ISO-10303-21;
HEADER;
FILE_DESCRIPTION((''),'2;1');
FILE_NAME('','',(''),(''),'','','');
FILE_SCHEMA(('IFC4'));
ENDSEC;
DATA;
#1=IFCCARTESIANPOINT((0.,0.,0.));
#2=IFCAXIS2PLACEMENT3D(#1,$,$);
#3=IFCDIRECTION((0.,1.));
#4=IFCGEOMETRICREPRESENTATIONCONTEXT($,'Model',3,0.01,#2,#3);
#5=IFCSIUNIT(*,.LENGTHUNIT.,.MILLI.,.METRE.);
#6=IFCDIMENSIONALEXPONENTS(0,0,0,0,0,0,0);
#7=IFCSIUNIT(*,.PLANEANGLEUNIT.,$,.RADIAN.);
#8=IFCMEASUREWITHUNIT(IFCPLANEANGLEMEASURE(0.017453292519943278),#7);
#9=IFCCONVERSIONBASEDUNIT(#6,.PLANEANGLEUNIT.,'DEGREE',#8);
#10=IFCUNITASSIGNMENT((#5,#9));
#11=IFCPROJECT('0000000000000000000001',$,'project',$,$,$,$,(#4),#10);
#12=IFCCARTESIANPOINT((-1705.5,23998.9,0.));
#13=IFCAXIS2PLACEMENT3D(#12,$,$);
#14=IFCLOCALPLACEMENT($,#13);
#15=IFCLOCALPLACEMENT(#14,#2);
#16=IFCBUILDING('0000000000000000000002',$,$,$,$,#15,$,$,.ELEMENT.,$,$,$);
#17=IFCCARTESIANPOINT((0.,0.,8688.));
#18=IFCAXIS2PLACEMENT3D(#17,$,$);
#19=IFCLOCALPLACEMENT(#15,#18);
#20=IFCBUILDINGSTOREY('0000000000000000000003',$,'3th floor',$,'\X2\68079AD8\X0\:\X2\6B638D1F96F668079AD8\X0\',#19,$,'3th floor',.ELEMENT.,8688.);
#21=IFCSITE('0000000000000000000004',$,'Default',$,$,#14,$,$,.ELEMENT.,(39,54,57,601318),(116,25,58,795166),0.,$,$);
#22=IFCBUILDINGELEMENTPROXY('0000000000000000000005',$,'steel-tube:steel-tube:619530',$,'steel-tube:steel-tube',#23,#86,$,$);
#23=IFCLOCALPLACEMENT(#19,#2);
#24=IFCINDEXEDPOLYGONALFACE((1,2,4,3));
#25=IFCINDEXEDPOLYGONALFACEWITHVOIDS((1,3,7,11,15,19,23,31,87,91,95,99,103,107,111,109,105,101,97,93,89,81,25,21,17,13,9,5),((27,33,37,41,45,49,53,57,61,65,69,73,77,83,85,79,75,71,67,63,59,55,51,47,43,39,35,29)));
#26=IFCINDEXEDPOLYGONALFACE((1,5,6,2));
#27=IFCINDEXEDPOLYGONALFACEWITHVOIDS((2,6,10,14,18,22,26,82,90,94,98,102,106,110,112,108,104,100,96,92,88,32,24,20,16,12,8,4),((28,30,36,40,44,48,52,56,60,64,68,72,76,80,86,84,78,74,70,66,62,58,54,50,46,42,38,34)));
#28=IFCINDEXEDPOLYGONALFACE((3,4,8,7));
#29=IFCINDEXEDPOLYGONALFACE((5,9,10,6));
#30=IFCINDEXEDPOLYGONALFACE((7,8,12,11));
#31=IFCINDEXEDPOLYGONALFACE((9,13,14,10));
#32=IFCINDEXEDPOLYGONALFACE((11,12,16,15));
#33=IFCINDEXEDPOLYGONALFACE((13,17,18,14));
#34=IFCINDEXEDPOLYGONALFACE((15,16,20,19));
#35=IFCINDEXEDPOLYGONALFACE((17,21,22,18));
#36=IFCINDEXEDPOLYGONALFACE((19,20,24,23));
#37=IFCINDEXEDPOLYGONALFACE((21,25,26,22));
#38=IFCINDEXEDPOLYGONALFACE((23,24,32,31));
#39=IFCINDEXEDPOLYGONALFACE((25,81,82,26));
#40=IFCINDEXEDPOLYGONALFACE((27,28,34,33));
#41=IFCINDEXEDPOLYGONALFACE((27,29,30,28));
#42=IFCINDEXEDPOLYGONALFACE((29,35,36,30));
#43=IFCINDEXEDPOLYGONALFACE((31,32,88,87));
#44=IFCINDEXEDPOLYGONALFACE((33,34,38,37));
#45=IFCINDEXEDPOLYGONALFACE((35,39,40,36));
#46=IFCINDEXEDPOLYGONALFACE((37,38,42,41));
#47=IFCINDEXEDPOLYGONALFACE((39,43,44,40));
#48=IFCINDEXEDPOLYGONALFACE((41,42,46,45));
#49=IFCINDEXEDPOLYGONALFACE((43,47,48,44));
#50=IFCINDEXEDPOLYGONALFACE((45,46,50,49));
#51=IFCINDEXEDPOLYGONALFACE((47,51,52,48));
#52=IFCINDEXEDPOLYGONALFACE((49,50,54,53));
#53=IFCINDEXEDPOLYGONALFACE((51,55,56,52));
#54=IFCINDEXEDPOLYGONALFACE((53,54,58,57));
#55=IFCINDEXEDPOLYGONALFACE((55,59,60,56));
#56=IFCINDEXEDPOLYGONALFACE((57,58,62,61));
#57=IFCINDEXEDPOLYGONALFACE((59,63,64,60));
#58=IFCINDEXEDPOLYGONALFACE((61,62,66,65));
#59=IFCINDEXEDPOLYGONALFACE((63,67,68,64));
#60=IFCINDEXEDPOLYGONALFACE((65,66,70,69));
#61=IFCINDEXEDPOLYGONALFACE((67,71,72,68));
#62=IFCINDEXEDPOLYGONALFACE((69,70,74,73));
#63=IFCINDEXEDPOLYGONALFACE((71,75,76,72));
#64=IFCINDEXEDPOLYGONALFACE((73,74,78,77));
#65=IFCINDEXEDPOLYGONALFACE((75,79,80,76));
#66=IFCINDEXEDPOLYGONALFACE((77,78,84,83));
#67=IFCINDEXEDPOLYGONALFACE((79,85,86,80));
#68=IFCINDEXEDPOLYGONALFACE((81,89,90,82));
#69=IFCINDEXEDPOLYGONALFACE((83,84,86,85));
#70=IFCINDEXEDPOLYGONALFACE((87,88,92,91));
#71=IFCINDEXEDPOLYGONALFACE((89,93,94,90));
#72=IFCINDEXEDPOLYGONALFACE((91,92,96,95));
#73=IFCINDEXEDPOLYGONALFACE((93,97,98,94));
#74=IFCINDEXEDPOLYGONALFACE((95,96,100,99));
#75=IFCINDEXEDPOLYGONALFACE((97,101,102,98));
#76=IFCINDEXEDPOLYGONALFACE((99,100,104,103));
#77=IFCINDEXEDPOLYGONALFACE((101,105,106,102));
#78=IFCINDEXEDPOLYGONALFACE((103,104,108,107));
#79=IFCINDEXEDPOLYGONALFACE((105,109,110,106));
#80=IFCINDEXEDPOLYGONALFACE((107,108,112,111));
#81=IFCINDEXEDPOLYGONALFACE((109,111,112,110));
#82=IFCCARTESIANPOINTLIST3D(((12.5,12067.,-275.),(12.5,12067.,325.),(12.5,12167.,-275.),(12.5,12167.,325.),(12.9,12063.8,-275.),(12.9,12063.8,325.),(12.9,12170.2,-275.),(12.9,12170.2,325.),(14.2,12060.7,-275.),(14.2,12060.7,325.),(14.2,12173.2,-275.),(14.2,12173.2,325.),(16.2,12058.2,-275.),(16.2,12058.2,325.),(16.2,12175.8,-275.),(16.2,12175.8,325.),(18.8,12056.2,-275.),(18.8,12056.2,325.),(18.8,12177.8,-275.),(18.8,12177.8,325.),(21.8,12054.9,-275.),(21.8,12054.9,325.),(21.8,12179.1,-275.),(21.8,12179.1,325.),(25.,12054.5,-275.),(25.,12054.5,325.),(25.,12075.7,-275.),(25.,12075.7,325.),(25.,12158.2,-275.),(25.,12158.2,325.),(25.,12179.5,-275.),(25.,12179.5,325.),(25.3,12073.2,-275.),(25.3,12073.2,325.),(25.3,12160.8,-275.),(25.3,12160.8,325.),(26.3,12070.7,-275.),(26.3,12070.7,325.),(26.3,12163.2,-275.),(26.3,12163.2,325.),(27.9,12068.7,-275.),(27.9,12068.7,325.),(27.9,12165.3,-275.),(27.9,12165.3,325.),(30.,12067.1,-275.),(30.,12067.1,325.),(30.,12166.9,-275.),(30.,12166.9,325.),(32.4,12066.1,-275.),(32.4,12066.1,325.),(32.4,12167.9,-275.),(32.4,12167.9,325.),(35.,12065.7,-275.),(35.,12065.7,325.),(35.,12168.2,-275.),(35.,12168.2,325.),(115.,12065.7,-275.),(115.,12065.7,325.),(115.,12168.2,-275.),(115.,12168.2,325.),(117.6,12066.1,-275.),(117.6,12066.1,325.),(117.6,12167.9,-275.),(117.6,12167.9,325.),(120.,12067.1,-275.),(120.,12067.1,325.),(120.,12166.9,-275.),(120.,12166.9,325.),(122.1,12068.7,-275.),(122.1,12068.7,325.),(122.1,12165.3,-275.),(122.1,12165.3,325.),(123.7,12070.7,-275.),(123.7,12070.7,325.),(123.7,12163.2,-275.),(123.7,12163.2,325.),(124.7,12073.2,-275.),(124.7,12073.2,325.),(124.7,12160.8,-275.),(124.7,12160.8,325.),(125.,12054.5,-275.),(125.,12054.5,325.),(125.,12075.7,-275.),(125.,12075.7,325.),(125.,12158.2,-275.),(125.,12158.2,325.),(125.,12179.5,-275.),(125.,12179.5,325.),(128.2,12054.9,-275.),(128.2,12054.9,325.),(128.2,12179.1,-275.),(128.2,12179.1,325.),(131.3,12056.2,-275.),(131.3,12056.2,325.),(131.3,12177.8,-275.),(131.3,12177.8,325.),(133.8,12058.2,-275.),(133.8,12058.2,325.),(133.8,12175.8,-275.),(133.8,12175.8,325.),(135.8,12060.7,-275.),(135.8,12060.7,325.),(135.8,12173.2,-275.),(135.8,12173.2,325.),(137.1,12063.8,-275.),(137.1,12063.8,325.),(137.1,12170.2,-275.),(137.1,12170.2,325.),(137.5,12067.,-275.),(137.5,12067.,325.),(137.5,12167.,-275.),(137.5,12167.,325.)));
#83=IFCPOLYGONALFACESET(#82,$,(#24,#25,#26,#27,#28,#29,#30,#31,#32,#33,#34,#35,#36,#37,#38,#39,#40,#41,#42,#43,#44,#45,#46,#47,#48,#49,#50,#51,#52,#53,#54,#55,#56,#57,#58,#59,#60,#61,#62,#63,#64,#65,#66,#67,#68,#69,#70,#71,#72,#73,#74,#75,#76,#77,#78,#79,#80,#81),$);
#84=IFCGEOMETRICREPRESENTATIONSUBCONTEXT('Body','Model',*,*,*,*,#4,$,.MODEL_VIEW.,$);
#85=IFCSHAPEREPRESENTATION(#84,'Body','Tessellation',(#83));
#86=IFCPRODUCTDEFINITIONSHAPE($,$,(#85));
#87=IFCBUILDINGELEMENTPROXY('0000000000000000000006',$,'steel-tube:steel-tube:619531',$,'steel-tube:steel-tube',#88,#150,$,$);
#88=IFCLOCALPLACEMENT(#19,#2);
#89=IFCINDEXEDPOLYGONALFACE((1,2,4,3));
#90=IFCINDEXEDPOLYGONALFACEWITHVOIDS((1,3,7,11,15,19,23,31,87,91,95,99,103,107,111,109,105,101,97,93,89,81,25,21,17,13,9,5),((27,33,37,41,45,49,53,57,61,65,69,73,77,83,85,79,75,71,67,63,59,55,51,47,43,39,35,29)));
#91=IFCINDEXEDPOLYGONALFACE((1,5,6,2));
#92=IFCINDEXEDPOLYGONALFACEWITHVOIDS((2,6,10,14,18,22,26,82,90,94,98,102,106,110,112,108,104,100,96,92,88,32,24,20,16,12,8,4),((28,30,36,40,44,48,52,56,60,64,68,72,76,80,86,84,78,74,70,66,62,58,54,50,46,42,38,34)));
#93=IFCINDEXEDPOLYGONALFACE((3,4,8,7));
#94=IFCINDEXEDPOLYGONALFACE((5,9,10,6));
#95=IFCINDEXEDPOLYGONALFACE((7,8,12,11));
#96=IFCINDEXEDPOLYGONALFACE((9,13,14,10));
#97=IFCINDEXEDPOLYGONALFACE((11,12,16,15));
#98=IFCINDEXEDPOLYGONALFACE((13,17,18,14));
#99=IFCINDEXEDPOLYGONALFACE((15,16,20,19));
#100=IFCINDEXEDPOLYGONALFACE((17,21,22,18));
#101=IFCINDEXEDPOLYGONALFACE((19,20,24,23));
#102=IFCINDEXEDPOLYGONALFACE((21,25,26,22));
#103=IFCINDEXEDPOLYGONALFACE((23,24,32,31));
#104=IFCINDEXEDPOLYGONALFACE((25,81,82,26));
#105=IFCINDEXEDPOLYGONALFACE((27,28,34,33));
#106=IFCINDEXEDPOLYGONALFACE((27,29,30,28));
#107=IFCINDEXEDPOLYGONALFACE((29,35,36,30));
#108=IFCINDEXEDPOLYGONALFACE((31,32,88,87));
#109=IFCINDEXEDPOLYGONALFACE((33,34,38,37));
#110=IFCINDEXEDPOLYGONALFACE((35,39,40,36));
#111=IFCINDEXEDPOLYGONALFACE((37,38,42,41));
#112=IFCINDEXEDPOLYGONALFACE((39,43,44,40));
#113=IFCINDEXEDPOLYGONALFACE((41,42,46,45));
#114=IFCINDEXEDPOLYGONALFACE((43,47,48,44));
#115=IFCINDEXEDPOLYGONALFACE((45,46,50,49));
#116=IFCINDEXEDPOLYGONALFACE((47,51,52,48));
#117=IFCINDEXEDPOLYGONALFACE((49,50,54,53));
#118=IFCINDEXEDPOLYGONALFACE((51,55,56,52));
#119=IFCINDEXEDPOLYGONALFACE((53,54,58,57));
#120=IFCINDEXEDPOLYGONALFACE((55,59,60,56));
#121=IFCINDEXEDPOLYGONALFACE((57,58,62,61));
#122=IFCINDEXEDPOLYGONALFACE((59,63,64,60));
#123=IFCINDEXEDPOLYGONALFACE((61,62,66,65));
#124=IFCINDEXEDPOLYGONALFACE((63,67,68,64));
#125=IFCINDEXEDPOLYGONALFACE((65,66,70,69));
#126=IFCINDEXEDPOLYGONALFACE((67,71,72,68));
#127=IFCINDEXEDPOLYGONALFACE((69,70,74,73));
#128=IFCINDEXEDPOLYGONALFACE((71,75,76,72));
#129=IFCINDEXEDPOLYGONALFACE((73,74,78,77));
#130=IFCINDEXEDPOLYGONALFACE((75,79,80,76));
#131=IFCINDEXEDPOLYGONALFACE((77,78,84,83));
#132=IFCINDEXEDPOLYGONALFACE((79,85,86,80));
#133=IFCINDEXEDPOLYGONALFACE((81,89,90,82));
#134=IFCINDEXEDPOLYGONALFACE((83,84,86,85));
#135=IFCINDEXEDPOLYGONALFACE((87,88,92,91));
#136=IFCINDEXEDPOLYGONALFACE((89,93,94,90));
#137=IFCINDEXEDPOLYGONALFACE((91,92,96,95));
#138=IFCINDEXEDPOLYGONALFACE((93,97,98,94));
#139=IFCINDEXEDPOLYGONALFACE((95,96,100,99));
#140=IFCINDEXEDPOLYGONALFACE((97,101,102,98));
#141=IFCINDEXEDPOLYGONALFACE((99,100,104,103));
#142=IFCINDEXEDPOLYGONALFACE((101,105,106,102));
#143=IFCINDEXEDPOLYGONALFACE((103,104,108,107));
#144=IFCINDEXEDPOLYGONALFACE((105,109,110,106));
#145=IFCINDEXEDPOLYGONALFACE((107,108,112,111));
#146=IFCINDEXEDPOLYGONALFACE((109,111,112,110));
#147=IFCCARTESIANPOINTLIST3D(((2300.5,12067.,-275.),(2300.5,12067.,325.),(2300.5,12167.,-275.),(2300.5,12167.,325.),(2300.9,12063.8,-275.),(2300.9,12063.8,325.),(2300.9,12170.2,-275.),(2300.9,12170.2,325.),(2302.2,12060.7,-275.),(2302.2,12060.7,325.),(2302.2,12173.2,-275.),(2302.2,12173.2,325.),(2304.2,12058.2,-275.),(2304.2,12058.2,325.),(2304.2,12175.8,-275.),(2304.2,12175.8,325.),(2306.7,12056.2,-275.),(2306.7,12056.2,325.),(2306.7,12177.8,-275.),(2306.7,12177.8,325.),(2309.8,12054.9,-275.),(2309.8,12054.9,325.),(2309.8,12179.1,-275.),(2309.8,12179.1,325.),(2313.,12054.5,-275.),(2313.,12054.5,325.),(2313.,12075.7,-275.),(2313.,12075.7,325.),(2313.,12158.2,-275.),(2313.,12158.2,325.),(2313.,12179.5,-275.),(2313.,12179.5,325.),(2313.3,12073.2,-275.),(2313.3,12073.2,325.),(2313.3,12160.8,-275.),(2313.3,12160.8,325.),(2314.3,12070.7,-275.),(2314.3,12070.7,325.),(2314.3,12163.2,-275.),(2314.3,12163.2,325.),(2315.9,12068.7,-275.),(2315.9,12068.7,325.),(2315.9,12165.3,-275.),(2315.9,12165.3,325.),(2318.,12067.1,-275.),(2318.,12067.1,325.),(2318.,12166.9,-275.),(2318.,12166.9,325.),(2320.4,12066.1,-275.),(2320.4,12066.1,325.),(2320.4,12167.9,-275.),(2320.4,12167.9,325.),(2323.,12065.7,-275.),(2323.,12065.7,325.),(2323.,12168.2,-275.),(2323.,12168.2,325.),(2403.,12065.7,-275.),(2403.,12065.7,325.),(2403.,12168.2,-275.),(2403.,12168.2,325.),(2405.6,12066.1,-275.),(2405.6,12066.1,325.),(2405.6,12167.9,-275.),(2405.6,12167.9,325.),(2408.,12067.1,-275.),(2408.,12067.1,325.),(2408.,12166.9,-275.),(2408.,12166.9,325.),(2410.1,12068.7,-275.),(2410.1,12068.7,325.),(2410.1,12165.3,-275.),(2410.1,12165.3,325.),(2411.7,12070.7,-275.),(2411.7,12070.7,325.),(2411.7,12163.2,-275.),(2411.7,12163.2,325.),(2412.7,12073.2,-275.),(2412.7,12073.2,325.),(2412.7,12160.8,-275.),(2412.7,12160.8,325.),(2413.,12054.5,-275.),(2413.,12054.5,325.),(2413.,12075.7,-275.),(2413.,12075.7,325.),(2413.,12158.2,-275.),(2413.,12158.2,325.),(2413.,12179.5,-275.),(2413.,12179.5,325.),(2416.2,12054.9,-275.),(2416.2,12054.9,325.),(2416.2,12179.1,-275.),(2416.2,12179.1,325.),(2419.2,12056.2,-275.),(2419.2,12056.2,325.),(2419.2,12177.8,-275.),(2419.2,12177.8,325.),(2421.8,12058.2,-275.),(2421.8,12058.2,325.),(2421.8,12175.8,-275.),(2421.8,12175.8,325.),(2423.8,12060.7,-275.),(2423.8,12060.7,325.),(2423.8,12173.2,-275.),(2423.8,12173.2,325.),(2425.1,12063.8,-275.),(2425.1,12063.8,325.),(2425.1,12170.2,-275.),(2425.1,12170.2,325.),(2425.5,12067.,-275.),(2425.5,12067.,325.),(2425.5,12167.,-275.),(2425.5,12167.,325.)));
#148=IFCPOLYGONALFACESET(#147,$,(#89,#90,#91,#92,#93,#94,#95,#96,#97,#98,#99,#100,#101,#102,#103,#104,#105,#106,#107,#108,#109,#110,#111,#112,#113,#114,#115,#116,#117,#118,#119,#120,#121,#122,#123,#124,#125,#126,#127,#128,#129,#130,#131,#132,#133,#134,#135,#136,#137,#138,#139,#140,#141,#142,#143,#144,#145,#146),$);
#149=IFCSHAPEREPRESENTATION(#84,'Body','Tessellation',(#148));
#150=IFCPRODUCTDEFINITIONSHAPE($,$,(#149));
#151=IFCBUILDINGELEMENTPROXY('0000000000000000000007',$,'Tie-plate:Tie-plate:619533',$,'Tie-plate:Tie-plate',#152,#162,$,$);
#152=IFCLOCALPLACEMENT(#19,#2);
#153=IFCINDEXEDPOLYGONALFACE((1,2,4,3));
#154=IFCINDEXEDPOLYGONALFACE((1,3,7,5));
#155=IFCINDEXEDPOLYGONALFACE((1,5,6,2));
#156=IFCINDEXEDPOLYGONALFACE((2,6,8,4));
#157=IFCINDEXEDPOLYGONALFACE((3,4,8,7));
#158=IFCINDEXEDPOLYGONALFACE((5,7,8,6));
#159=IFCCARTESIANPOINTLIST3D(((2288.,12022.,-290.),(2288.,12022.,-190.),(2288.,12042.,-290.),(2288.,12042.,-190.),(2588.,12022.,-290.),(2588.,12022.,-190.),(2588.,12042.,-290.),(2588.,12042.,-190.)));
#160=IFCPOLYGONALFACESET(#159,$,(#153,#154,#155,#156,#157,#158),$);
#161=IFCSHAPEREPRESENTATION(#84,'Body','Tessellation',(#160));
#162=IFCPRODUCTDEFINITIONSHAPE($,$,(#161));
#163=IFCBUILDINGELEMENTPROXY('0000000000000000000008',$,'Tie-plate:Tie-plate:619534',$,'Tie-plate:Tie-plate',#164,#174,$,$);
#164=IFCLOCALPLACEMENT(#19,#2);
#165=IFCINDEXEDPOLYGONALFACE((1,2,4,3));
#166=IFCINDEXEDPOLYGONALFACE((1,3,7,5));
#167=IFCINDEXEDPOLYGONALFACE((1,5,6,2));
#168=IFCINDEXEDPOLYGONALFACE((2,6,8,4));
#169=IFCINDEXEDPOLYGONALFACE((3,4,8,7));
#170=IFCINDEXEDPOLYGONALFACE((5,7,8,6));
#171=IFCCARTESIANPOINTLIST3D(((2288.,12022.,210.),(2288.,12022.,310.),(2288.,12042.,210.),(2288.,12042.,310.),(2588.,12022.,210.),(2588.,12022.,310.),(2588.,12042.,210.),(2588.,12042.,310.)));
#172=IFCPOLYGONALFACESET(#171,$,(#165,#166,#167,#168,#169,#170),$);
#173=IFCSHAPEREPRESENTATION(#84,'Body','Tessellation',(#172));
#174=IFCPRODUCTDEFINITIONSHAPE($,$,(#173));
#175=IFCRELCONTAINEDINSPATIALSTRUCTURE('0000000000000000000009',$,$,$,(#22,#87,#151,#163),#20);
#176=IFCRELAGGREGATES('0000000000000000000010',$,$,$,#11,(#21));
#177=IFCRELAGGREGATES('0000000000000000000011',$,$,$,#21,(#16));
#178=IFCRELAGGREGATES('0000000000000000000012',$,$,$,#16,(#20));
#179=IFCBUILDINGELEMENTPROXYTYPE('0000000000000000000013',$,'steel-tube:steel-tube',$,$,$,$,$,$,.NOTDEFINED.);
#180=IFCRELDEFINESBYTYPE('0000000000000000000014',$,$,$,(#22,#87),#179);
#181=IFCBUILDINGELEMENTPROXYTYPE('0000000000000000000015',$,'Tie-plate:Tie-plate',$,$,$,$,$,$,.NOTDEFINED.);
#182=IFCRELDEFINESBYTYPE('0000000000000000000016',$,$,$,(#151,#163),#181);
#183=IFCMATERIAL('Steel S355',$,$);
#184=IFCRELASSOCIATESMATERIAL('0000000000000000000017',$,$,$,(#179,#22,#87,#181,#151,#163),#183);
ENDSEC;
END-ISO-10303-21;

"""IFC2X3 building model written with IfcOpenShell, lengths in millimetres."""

from ifc_helpers import new_model, entity, si_unit, converted_unit, direction, frame, frame_2d, origin, place, context, subcontext, project, spatial, polyline, circle_curve, parameter, trimmed, segment, composite_curve, rectangle, outline, extrude, source, transform, mapped, material, type_object, type_shapes, element, save


model = new_model("IFC2X3")

# Units and contexts
model_context = context("Model", 3, precision=0.01, world=origin(), true_north=direction((0.0, 1.0)))
body_context = subcontext(model_context, "Body", "Model", "MODEL_VIEW")
ifc_project = project(units=[si_unit("LENGTHUNIT", "METRE", prefix="MILLI"), converted_unit("PLANEANGLEUNIT", "DEGREE", entity("IfcPlaneAngleMeasure", 0.017453292519943278), si_unit("PLANEANGLEUNIT", "RADIAN"), dimensions=[0, 0, 0, 0, 0, 0, 0])], contexts=[model_context])

# Site, building, storey
site_placement = place(None, frame((-1705.5, 23998.9, 0.0)))
site = spatial("IfcSite", under=ifc_project, at=site_placement, Name="Default", CompositionType="ELEMENT", RefLatitude=(39, 54, 57, 601318), RefLongitude=(116, 25, 58, 795166), RefElevation=0.0)
building_placement = place(site_placement, origin())
building = spatial("IfcBuilding", under=site, at=building_placement, CompositionType="ELEMENT")
storey_placement = place(building_placement, frame((0.0, 0.0, 8688.0)))
storey = spatial("IfcBuildingStorey", under=building, at=storey_placement, Name="3th floor", ObjectType="标高:正负零标高", LongName="3th floor", CompositionType="ELEMENT", Elevation=8688.0)

# Shared definitions
ifc_material_1 = material(Name="Steel S355")

# Building element proxies
building_element_proxy_type_1 = type_object("IfcBuildingElementProxyType", Name="steel-tube:steel-tube", PredefinedType="NOTDEFINED", material=ifc_material_1)
shared_shape_1 = source(origin(), body_context, "Body", "SweptSolid", [
    extrude(outline(composite_curve([segment(trimmed(circle_curve(frame_2d((50.0, -50.0), x_axis=(1.0, 0.0)), 12.5), [parameter(270.0)], [parameter(0.0)], True, "PARAMETER"), True, "CONTINUOUS"), segment(polyline([(62.5, -50.0), (62.5, 50.0)]), True, "CONTINUOUS"), segment(trimmed(circle_curve(frame_2d((50.0, 50.0), x_axis=(1.0, 0.0)), 12.5), [parameter(0.0)], [parameter(90.0)], True, "PARAMETER"), True, "CONTINUOUS"), segment(polyline([(50.0, 62.5), (-50.0, 62.5)]), True, "CONTINUOUS"), segment(trimmed(circle_curve(frame_2d((-50.0, 50.0), x_axis=(1.0, 0.0)), 12.5), [parameter(90.0)], [parameter(180.0)], True, "PARAMETER"), True, "CONTINUOUS"), segment(polyline([(-62.5, 50.0), (-62.5, -50.0)]), True, "CONTINUOUS"), segment(trimmed(circle_curve(frame_2d((-50.0, -50.0), x_axis=(1.0, 0.0)), 12.5), [parameter(180.0)], [parameter(270.0)], True, "PARAMETER"), True, "CONTINUOUS"), segment(polyline([(-50.0, -62.5), (50.0, -62.5)]), True, "CONTINUOUS")], self_intersect=False), holes=[composite_curve([segment(trimmed(circle_curve(frame_2d((-41.2, 40.0), x_axis=(1.0, 0.0)), 10.0), [parameter(90.0)], [parameter(180.0)], True, "PARAMETER"), False, "CONTINUOUS"), segment(polyline([(-41.3, 50.0), (41.2, 50.0)]), True, "CONTINUOUS"), segment(trimmed(circle_curve(frame_2d((41.2, 40.0), x_axis=(1.0, 0.0)), 10.0), [parameter(0.0)], [parameter(90.0)], True, "PARAMETER"), False, "CONTINUOUS"), segment(polyline([(51.2, 40.0), (51.2, -40.0)]), True, "CONTINUOUS"), segment(trimmed(circle_curve(frame_2d((41.2, -40.0), x_axis=(1.0, 0.0)), 10.0), [parameter(270.0)], [parameter(360.0)], True, "PARAMETER"), False, "CONTINUOUS"), segment(polyline([(41.2, -50.0), (-41.3, -50.0)]), True, "CONTINUOUS"), segment(trimmed(circle_curve(frame_2d((-41.3, -40.0), x_axis=(1.0, 0.0)), 10.0), [parameter(180.0)], [parameter(270.0)], True, "PARAMETER"), False, "CONTINUOUS"), segment(polyline([(-51.3, -40.0), (-51.3, 40.0)]), True, "CONTINUOUS")], self_intersect=False)]), frame((62.5, 62.5, -175.0)), (0.0, 0.0, 1.0), 600.0),
])
type_shapes(building_element_proxy_type_1, [shared_shape_1])
for number, where, z_axis, x_axis, name in (
    (1, (12.5, 12179.5, -100.0), (0.0, 0.0, 1.0), (0.0, -1.0, 0.0), "steel-tube:steel-tube:619530"),
    (2, (2300.5, 12179.5, -100.0), (0.0, 0.0, 1.0), (0.0, -1.0, 0.0), "steel-tube:steel-tube:619531"),
):
    element("IfcBuildingElementProxy", number, at=place(storey_placement, frame(where, z_axis=z_axis, x_axis=x_axis)), inside=storey, type_object=building_element_proxy_type_1, material=ifc_material_1, Name=name, ObjectType="steel-tube:steel-tube", context=body_context, shape_type="MappedRepresentation", body=[
        mapped(shared_shape_1, transform((0.0, 0.0, 0.0), scale=1.0)),
    ])
building_element_proxy_type_2 = type_object("IfcBuildingElementProxyType", Name="Tie-plate:Tie-plate", PredefinedType="NOTDEFINED", material=ifc_material_1)
shared_shape_2 = source(origin(), body_context, "Body", "SweptSolid", [
    extrude(rectangle(XDim=300.0, YDim=20.0, at=frame_2d((0.0, 0.0), x_axis=(1.0, 0.0))), frame((150.0, -10.0, 0.0), z_axis=(0.0, 0.0, 1.0), x_axis=(-1.0, 0.0, 0.0)), (0.0, 0.0, 1.0), 100.0),
])
type_shapes(building_element_proxy_type_2, [shared_shape_2])
for number, where, name in (
    (3, (2288.0, 12042.0, -290.0), "Tie-plate:Tie-plate:619533"),
    (4, (2288.0, 12042.0, 210.0), "Tie-plate:Tie-plate:619534"),
):
    element("IfcBuildingElementProxy", number, at=place(storey_placement, frame(where)), inside=storey, type_object=building_element_proxy_type_2, material=ifc_material_1, Name=name, ObjectType="Tie-plate:Tie-plate", context=body_context, shape_type="MappedRepresentation", body=[
        mapped(shared_shape_2, transform((0.0, 0.0, 0.0), scale=1.0)),
    ])

save(model, "model.ifc")
